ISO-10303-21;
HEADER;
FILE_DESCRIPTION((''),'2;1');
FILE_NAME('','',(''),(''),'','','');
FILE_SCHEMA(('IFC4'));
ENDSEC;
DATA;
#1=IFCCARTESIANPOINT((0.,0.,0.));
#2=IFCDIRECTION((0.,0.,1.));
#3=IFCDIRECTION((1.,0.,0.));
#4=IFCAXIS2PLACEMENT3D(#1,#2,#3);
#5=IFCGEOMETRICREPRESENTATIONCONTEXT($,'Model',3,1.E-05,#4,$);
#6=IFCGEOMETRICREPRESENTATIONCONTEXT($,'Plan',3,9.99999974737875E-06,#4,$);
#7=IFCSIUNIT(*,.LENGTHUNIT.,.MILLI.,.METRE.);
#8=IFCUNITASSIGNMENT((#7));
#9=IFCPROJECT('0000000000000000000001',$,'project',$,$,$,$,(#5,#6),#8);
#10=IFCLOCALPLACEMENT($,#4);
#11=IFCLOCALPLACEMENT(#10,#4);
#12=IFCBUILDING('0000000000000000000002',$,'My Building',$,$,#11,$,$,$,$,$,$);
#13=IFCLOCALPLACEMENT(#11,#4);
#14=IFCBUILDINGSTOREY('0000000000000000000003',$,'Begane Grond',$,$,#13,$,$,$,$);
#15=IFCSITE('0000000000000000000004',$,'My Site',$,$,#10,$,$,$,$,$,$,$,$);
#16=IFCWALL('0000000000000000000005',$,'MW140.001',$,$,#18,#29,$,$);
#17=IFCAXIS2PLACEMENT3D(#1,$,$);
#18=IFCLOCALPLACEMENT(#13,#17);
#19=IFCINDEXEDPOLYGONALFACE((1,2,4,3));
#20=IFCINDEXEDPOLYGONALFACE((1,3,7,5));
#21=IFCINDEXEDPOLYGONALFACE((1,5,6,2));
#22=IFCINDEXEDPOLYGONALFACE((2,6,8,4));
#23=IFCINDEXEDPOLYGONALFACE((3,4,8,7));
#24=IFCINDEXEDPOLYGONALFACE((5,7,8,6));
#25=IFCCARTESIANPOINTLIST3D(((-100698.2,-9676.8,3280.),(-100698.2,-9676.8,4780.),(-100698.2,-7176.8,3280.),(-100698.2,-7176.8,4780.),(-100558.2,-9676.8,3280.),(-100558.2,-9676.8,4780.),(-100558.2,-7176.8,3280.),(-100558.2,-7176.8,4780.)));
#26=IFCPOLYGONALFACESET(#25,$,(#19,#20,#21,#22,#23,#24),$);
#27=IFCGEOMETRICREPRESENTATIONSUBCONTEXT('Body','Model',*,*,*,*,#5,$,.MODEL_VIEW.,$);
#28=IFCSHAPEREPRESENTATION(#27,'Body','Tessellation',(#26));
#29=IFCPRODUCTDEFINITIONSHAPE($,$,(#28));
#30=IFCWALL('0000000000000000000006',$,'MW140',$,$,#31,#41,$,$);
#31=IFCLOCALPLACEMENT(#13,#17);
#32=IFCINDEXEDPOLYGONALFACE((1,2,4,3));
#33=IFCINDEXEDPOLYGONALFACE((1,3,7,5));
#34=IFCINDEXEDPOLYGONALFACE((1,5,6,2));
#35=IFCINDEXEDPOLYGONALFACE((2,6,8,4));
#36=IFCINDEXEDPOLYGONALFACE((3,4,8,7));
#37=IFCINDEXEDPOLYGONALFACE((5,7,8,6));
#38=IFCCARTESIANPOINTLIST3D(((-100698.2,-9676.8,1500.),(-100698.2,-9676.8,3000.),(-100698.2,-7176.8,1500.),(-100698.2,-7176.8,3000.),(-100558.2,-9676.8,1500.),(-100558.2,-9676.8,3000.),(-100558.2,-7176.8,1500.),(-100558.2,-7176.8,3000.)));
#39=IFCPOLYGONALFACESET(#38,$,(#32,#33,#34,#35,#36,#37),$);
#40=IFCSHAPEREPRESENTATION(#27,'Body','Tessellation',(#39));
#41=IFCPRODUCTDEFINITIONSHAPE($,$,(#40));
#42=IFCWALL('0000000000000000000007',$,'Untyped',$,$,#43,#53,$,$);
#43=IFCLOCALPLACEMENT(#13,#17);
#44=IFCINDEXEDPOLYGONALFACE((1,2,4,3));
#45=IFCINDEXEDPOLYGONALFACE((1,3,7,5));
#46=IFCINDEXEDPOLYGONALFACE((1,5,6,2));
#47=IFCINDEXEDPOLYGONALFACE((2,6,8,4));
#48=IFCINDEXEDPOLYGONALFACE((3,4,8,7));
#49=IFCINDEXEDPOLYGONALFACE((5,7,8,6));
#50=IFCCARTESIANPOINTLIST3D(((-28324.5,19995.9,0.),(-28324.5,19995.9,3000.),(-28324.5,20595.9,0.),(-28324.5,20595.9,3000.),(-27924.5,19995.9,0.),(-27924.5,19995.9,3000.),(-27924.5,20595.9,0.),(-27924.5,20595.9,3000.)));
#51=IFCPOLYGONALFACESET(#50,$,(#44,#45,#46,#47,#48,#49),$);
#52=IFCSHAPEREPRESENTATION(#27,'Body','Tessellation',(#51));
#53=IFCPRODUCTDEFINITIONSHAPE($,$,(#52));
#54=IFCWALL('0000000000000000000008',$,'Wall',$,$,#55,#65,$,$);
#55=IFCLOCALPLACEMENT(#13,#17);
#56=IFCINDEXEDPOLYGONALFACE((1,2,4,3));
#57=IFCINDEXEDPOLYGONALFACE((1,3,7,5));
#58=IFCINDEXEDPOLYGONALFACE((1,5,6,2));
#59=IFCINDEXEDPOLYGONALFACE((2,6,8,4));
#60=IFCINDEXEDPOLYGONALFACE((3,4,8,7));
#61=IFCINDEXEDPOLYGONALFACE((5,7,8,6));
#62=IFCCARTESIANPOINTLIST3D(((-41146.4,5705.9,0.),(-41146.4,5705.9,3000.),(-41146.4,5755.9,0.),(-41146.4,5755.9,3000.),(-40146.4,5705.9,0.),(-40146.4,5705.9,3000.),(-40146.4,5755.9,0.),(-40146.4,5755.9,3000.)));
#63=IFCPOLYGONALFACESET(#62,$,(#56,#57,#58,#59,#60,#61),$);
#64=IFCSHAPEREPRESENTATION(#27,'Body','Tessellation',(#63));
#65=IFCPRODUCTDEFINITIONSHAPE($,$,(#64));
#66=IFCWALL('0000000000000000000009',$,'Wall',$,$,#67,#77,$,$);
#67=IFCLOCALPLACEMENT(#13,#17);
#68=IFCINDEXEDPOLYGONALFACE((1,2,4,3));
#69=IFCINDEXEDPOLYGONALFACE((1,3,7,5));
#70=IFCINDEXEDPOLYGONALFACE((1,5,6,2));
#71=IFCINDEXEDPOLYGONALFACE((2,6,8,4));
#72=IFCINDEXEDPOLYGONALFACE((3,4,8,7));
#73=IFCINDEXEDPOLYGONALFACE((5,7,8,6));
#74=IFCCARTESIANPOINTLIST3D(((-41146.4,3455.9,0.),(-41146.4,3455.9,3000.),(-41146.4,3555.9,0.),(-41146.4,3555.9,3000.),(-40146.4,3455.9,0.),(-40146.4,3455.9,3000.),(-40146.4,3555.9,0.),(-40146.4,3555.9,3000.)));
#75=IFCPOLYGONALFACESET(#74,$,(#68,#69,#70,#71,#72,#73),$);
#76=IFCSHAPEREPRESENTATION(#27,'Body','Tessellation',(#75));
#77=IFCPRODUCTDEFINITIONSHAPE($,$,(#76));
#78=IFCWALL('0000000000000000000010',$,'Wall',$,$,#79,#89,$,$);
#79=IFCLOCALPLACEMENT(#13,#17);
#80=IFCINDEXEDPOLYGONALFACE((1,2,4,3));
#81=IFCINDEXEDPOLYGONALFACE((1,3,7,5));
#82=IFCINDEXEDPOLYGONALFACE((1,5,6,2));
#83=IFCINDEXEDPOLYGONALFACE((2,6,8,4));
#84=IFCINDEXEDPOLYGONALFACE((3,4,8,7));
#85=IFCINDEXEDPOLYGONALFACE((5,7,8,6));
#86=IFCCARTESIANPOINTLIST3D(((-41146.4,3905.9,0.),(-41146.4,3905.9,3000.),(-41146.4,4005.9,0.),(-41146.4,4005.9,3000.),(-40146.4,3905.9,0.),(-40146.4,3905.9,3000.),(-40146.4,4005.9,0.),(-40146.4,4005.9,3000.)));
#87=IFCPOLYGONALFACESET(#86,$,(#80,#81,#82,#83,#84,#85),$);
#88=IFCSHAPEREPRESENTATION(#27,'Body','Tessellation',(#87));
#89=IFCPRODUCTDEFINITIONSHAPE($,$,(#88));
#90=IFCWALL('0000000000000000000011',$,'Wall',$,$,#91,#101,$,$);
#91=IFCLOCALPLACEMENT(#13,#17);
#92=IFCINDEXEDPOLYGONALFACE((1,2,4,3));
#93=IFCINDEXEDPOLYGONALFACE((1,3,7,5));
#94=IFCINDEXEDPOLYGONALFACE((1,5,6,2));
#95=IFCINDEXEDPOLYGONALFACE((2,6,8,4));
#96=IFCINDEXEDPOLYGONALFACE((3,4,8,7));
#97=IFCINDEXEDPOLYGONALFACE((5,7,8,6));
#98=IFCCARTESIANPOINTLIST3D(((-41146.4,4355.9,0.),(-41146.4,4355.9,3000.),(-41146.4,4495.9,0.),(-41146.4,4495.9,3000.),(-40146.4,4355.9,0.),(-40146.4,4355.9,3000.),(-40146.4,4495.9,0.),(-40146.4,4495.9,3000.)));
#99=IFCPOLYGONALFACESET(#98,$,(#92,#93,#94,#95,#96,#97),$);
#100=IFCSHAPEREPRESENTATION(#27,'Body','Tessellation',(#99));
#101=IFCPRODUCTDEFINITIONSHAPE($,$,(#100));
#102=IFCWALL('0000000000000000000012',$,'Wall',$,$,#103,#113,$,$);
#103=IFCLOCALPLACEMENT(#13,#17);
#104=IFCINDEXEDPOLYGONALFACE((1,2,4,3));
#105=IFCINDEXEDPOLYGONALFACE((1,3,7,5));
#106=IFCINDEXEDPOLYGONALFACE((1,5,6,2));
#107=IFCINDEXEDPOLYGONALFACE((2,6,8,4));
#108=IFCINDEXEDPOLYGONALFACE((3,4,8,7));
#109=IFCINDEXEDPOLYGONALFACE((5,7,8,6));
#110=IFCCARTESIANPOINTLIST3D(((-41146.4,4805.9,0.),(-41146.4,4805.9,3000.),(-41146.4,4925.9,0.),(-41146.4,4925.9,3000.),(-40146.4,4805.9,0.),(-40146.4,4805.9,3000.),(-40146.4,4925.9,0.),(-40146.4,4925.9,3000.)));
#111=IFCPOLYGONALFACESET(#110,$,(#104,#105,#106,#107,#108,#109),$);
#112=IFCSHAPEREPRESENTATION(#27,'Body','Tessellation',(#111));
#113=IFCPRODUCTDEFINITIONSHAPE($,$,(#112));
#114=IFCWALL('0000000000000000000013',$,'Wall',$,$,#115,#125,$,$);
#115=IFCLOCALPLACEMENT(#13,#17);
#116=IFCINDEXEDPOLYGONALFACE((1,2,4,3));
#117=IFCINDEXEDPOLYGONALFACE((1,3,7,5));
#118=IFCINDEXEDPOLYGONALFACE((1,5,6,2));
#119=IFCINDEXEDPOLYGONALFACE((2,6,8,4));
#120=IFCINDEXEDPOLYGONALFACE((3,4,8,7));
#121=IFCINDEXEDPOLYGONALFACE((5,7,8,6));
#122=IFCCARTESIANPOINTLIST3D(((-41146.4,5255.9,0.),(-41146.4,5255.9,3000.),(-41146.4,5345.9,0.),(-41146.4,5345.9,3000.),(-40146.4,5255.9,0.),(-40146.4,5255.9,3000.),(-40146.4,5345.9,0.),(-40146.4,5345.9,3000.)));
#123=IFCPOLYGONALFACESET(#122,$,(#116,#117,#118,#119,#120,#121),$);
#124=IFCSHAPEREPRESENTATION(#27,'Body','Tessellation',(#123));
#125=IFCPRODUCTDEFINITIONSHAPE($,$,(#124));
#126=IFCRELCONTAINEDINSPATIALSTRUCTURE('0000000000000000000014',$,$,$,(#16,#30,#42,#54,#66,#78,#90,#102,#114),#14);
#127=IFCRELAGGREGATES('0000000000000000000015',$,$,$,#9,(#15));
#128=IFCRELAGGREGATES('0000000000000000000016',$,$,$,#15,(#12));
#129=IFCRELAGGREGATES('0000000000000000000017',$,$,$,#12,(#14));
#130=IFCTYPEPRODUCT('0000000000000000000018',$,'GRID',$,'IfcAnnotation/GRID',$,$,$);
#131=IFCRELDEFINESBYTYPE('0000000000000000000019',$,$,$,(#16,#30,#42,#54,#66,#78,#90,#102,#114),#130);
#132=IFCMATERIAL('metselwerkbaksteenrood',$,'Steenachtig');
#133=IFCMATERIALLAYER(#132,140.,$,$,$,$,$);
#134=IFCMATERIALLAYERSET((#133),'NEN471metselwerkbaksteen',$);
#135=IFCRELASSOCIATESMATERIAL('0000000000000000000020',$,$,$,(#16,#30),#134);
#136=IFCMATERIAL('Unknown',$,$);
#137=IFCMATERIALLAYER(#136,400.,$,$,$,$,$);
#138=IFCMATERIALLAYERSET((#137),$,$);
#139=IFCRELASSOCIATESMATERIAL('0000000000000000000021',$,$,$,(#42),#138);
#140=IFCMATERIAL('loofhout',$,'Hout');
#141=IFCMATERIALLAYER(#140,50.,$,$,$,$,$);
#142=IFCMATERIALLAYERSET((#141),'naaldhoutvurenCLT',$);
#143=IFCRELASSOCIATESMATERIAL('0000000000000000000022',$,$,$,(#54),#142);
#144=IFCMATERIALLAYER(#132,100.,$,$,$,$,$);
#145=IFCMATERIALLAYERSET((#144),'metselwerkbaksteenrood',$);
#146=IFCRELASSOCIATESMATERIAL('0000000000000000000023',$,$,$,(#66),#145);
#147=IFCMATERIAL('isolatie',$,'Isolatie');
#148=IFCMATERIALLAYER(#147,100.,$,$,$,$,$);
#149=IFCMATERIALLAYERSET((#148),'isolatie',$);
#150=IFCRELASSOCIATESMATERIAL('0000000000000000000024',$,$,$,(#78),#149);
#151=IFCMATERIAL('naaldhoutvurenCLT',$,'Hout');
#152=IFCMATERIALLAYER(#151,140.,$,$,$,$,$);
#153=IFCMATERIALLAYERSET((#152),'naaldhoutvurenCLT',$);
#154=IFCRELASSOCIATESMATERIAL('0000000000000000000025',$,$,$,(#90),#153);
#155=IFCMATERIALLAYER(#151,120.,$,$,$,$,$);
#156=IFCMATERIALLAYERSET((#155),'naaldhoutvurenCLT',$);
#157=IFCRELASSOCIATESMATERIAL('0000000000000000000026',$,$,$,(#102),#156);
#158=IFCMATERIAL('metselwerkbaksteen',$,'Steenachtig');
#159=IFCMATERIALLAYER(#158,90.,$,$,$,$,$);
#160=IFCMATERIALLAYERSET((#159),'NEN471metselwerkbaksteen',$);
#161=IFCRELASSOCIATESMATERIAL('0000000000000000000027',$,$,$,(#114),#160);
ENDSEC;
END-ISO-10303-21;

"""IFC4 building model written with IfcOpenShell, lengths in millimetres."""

from ifc_helpers import new_model, si_unit, frame, origin_with_axes, place, context, subcontext, project, spatial, indexed_curve, outline, extrude, material, layer, layer_set, layer_usage, type_object, element, save


model = new_model("IFC4")

# Units and contexts
model_context = context("Model", 3, precision=1e-05, world=origin_with_axes())
plan_context = context("Plan", 3, precision=9.99999974737875e-06, world=origin_with_axes())
body_context = subcontext(model_context, "Body", "Model", "MODEL_VIEW")
ifc_project = project(units=[si_unit("LENGTHUNIT", "METRE", prefix="MILLI")], contexts=[model_context, plan_context])

# Site, building, storey
site_placement = place(None, frame((0.0, 0.0, 0.0), z_axis=(0.0, 0.0, 1.0), x_axis=(1.0, 0.0, 0.0)))
site = spatial("IfcSite", under=ifc_project, at=site_placement, Name="My Site")
building_placement = place(site_placement, origin_with_axes())
building = spatial("IfcBuilding", under=site, at=building_placement, Name="My Building")
storey_placement = place(building_placement, origin_with_axes())
storey = spatial("IfcBuildingStorey", under=building, at=storey_placement, Name="Begane Grond")

# Shared definitions
type_product = type_object("IfcTypeProduct", Name="GRID", ApplicableOccurrence="IfcAnnotation/GRID")

# Shared definitions
ifc_material_1 = material(Name="naaldhoutvurenCLT", Category="Hout")
ifc_material_2 = material(Name="isolatie", Category="Isolatie")

# Walls
ifc_material_3 = material(Name="metselwerkbaksteenrood", Category="Steenachtig")
ifc_layer_1 = layer(ifc_material_3, 140.0)
ifc_layer_set_1 = layer_set([ifc_layer_1], Name="NEN471metselwerkbaksteen")
ifc_layer_usage_1 = layer_usage(ifc_layer_set_1, "AXIS2", "POSITIVE", 0.0)
wall_1_placement = place(storey_placement, frame((-100558.2, -9676.8, 3280.0), z_axis=(0.0, 0.0, 1.0), x_axis=(0.0, 1.0, 0.0)))
element("IfcWall", 1, at=wall_1_placement, inside=storey, type_object=type_product, material=ifc_layer_usage_1, Name="MW140.001", context=body_context, shape_type="SweptSolid", body=[
    extrude(outline(indexed_curve([(0.0, 0.0), (0.0, 140.0), (2500.0, 140.0), (2500.0, 0.0), (0.0, 0.0)], self_intersect=False)), origin_with_axes(), (0.0, 0.0, 1.0), 1500.0),
])
ifc_layer_usage_2 = layer_usage(ifc_layer_set_1, "AXIS2", "POSITIVE", 0.0)
wall_2_placement = place(storey_placement, frame((-100558.2, -9676.8, 1500.0), z_axis=(0.0, 0.0, 1.0), x_axis=(0.0, 1.0, 0.0)))
element("IfcWall", 2, at=wall_2_placement, inside=storey, type_object=type_product, material=ifc_layer_usage_2, Name="MW140", context=body_context, shape_type="SweptSolid", body=[
    extrude(outline(indexed_curve([(0.0, 0.0), (0.0, 140.0), (2500.0, 140.0), (2500.0, 0.0), (0.0, 0.0)], self_intersect=False)), origin_with_axes(), (0.0, 0.0, 1.0), 1500.0),
])
ifc_material_4 = material(Name="Unknown")
ifc_layer_2 = layer(ifc_material_4, 400.0)
ifc_layer_set_2 = layer_set([ifc_layer_2])
ifc_layer_usage_3 = layer_usage(ifc_layer_set_2, "AXIS2", "POSITIVE", 0.0)
wall_3_placement = place(storey_placement, frame((-27924.5, 19995.9, 0.0), z_axis=(0.0, 0.0, 1.0), x_axis=(0.0, 1.0, 0.0)))
element("IfcWall", 3, at=wall_3_placement, inside=storey, type_object=type_product, material=ifc_layer_usage_3, Name="Untyped", context=body_context, shape_type="SweptSolid", body=[
    extrude(outline(indexed_curve([(0.0, 0.0), (0.0, 400.0), (600.0, 400.0), (600.0, 0.0), (0.0, 0.0)], self_intersect=False)), origin_with_axes(), (0.0, 0.0, 1.0), 3000.0),
])
ifc_material_5 = material(Name="loofhout", Category="Hout")
ifc_layer_3 = layer(ifc_material_5, 50.0)
ifc_layer_set_3 = layer_set([ifc_layer_3], Name="naaldhoutvurenCLT")
ifc_layer_usage_4 = layer_usage(ifc_layer_set_3, "AXIS2", "POSITIVE", 0.0)
wall_4_placement = place(storey_placement, frame((-41146.4, 5705.9, 0.0), z_axis=(0.0, 0.0, 1.0), x_axis=(1.0, 0.0, 0.0)))
element("IfcWall", 4, at=wall_4_placement, inside=storey, type_object=type_product, material=ifc_layer_usage_4, Name="Wall", context=body_context, shape_type="SweptSolid", body=[
    extrude(outline(indexed_curve([(0.0, 0.0), (0.0, 50.0), (1000.0, 50.0), (1000.0, 0.0), (0.0, 0.0)], self_intersect=False)), origin_with_axes(), (0.0, 0.0, 1.0), 3000.0),
])
ifc_layer_4 = layer(ifc_material_3, 100.0)
ifc_layer_set_4 = layer_set([ifc_layer_4], Name="metselwerkbaksteenrood")
ifc_layer_usage_5 = layer_usage(ifc_layer_set_4, "AXIS2", "POSITIVE", 0.0)
wall_5_placement = place(storey_placement, frame((-41146.4, 3455.9, 0.0), z_axis=(0.0, 0.0, 1.0), x_axis=(1.0, 0.0, 0.0)))
element("IfcWall", 5, at=wall_5_placement, inside=storey, type_object=type_product, material=ifc_layer_usage_5, Name="Wall", context=body_context, shape_type="SweptSolid", body=[
    extrude(outline(indexed_curve([(0.0, 0.0), (0.0, 100.0), (1000.0, 100.0), (1000.0, 0.0), (0.0, 0.0)], self_intersect=False)), origin_with_axes(), (0.0, 0.0, 1.0), 3000.0),
])
ifc_layer_5 = layer(ifc_material_2, 100.0)
ifc_layer_set_5 = layer_set([ifc_layer_5], Name="isolatie")
ifc_layer_usage_6 = layer_usage(ifc_layer_set_5, "AXIS2", "POSITIVE", 0.0)
wall_6_placement = place(storey_placement, frame((-41146.4, 3905.9, 0.0), z_axis=(0.0, 0.0, 1.0), x_axis=(1.0, 0.0, 0.0)))
element("IfcWall", 6, at=wall_6_placement, inside=storey, type_object=type_product, material=ifc_layer_usage_6, Name="Wall", context=body_context, shape_type="SweptSolid", body=[
    extrude(outline(indexed_curve([(0.0, 0.0), (0.0, 100.0), (1000.0, 100.0), (1000.0, 0.0), (0.0, 0.0)], self_intersect=False)), origin_with_axes(), (0.0, 0.0, 1.0), 3000.0),
])
ifc_layer_6 = layer(ifc_material_1, 140.0)
ifc_layer_set_6 = layer_set([ifc_layer_6], Name="naaldhoutvurenCLT")
ifc_layer_usage_7 = layer_usage(ifc_layer_set_6, "AXIS2", "POSITIVE", 0.0)
wall_7_placement = place(storey_placement, frame((-41146.4, 4355.9, 0.0), z_axis=(0.0, 0.0, 1.0), x_axis=(1.0, 0.0, 0.0)))
element("IfcWall", 7, at=wall_7_placement, inside=storey, type_object=type_product, material=ifc_layer_usage_7, Name="Wall", context=body_context, shape_type="SweptSolid", body=[
    extrude(outline(indexed_curve([(0.0, 0.0), (0.0, 140.0), (1000.0, 140.0), (1000.0, 0.0), (0.0, 0.0)], self_intersect=False)), origin_with_axes(), (0.0, 0.0, 1.0), 3000.0),
])
ifc_layer_7 = layer(ifc_material_1, 120.0)
ifc_layer_set_7 = layer_set([ifc_layer_7], Name="naaldhoutvurenCLT")
ifc_layer_usage_8 = layer_usage(ifc_layer_set_7, "AXIS2", "POSITIVE", 0.0)
wall_8_placement = place(storey_placement, frame((-41146.4, 4805.9, 0.0), z_axis=(0.0, 0.0, 1.0), x_axis=(1.0, 0.0, 0.0)))
element("IfcWall", 8, at=wall_8_placement, inside=storey, type_object=type_product, material=ifc_layer_usage_8, Name="Wall", context=body_context, shape_type="SweptSolid", body=[
    extrude(outline(indexed_curve([(0.0, 0.0), (0.0, 120.0), (1000.0, 120.0), (1000.0, 0.0), (0.0, 0.0)], self_intersect=False)), origin_with_axes(), (0.0, 0.0, 1.0), 3000.0),
])
ifc_material_6 = material(Name="metselwerkbaksteen", Category="Steenachtig")
ifc_layer_8 = layer(ifc_material_6, 90.0)
ifc_layer_set_8 = layer_set([ifc_layer_8], Name="NEN471metselwerkbaksteen")
ifc_layer_usage_9 = layer_usage(ifc_layer_set_8, "AXIS2", "POSITIVE", 0.0)
wall_9_placement = place(storey_placement, frame((-41146.4, 5255.9, 0.0), z_axis=(0.0, 0.0, 1.0), x_axis=(1.0, 0.0, 0.0)))
element("IfcWall", 9, at=wall_9_placement, inside=storey, type_object=type_product, material=ifc_layer_usage_9, Name="Wall", context=body_context, shape_type="SweptSolid", body=[
    extrude(outline(indexed_curve([(0.0, 0.0), (0.0, 90.0), (1000.0, 90.0), (1000.0, 0.0), (0.0, 0.0)], self_intersect=False)), origin_with_axes(), (0.0, 0.0, 1.0), 3000.0),
])

save(model, "model.ifc")
